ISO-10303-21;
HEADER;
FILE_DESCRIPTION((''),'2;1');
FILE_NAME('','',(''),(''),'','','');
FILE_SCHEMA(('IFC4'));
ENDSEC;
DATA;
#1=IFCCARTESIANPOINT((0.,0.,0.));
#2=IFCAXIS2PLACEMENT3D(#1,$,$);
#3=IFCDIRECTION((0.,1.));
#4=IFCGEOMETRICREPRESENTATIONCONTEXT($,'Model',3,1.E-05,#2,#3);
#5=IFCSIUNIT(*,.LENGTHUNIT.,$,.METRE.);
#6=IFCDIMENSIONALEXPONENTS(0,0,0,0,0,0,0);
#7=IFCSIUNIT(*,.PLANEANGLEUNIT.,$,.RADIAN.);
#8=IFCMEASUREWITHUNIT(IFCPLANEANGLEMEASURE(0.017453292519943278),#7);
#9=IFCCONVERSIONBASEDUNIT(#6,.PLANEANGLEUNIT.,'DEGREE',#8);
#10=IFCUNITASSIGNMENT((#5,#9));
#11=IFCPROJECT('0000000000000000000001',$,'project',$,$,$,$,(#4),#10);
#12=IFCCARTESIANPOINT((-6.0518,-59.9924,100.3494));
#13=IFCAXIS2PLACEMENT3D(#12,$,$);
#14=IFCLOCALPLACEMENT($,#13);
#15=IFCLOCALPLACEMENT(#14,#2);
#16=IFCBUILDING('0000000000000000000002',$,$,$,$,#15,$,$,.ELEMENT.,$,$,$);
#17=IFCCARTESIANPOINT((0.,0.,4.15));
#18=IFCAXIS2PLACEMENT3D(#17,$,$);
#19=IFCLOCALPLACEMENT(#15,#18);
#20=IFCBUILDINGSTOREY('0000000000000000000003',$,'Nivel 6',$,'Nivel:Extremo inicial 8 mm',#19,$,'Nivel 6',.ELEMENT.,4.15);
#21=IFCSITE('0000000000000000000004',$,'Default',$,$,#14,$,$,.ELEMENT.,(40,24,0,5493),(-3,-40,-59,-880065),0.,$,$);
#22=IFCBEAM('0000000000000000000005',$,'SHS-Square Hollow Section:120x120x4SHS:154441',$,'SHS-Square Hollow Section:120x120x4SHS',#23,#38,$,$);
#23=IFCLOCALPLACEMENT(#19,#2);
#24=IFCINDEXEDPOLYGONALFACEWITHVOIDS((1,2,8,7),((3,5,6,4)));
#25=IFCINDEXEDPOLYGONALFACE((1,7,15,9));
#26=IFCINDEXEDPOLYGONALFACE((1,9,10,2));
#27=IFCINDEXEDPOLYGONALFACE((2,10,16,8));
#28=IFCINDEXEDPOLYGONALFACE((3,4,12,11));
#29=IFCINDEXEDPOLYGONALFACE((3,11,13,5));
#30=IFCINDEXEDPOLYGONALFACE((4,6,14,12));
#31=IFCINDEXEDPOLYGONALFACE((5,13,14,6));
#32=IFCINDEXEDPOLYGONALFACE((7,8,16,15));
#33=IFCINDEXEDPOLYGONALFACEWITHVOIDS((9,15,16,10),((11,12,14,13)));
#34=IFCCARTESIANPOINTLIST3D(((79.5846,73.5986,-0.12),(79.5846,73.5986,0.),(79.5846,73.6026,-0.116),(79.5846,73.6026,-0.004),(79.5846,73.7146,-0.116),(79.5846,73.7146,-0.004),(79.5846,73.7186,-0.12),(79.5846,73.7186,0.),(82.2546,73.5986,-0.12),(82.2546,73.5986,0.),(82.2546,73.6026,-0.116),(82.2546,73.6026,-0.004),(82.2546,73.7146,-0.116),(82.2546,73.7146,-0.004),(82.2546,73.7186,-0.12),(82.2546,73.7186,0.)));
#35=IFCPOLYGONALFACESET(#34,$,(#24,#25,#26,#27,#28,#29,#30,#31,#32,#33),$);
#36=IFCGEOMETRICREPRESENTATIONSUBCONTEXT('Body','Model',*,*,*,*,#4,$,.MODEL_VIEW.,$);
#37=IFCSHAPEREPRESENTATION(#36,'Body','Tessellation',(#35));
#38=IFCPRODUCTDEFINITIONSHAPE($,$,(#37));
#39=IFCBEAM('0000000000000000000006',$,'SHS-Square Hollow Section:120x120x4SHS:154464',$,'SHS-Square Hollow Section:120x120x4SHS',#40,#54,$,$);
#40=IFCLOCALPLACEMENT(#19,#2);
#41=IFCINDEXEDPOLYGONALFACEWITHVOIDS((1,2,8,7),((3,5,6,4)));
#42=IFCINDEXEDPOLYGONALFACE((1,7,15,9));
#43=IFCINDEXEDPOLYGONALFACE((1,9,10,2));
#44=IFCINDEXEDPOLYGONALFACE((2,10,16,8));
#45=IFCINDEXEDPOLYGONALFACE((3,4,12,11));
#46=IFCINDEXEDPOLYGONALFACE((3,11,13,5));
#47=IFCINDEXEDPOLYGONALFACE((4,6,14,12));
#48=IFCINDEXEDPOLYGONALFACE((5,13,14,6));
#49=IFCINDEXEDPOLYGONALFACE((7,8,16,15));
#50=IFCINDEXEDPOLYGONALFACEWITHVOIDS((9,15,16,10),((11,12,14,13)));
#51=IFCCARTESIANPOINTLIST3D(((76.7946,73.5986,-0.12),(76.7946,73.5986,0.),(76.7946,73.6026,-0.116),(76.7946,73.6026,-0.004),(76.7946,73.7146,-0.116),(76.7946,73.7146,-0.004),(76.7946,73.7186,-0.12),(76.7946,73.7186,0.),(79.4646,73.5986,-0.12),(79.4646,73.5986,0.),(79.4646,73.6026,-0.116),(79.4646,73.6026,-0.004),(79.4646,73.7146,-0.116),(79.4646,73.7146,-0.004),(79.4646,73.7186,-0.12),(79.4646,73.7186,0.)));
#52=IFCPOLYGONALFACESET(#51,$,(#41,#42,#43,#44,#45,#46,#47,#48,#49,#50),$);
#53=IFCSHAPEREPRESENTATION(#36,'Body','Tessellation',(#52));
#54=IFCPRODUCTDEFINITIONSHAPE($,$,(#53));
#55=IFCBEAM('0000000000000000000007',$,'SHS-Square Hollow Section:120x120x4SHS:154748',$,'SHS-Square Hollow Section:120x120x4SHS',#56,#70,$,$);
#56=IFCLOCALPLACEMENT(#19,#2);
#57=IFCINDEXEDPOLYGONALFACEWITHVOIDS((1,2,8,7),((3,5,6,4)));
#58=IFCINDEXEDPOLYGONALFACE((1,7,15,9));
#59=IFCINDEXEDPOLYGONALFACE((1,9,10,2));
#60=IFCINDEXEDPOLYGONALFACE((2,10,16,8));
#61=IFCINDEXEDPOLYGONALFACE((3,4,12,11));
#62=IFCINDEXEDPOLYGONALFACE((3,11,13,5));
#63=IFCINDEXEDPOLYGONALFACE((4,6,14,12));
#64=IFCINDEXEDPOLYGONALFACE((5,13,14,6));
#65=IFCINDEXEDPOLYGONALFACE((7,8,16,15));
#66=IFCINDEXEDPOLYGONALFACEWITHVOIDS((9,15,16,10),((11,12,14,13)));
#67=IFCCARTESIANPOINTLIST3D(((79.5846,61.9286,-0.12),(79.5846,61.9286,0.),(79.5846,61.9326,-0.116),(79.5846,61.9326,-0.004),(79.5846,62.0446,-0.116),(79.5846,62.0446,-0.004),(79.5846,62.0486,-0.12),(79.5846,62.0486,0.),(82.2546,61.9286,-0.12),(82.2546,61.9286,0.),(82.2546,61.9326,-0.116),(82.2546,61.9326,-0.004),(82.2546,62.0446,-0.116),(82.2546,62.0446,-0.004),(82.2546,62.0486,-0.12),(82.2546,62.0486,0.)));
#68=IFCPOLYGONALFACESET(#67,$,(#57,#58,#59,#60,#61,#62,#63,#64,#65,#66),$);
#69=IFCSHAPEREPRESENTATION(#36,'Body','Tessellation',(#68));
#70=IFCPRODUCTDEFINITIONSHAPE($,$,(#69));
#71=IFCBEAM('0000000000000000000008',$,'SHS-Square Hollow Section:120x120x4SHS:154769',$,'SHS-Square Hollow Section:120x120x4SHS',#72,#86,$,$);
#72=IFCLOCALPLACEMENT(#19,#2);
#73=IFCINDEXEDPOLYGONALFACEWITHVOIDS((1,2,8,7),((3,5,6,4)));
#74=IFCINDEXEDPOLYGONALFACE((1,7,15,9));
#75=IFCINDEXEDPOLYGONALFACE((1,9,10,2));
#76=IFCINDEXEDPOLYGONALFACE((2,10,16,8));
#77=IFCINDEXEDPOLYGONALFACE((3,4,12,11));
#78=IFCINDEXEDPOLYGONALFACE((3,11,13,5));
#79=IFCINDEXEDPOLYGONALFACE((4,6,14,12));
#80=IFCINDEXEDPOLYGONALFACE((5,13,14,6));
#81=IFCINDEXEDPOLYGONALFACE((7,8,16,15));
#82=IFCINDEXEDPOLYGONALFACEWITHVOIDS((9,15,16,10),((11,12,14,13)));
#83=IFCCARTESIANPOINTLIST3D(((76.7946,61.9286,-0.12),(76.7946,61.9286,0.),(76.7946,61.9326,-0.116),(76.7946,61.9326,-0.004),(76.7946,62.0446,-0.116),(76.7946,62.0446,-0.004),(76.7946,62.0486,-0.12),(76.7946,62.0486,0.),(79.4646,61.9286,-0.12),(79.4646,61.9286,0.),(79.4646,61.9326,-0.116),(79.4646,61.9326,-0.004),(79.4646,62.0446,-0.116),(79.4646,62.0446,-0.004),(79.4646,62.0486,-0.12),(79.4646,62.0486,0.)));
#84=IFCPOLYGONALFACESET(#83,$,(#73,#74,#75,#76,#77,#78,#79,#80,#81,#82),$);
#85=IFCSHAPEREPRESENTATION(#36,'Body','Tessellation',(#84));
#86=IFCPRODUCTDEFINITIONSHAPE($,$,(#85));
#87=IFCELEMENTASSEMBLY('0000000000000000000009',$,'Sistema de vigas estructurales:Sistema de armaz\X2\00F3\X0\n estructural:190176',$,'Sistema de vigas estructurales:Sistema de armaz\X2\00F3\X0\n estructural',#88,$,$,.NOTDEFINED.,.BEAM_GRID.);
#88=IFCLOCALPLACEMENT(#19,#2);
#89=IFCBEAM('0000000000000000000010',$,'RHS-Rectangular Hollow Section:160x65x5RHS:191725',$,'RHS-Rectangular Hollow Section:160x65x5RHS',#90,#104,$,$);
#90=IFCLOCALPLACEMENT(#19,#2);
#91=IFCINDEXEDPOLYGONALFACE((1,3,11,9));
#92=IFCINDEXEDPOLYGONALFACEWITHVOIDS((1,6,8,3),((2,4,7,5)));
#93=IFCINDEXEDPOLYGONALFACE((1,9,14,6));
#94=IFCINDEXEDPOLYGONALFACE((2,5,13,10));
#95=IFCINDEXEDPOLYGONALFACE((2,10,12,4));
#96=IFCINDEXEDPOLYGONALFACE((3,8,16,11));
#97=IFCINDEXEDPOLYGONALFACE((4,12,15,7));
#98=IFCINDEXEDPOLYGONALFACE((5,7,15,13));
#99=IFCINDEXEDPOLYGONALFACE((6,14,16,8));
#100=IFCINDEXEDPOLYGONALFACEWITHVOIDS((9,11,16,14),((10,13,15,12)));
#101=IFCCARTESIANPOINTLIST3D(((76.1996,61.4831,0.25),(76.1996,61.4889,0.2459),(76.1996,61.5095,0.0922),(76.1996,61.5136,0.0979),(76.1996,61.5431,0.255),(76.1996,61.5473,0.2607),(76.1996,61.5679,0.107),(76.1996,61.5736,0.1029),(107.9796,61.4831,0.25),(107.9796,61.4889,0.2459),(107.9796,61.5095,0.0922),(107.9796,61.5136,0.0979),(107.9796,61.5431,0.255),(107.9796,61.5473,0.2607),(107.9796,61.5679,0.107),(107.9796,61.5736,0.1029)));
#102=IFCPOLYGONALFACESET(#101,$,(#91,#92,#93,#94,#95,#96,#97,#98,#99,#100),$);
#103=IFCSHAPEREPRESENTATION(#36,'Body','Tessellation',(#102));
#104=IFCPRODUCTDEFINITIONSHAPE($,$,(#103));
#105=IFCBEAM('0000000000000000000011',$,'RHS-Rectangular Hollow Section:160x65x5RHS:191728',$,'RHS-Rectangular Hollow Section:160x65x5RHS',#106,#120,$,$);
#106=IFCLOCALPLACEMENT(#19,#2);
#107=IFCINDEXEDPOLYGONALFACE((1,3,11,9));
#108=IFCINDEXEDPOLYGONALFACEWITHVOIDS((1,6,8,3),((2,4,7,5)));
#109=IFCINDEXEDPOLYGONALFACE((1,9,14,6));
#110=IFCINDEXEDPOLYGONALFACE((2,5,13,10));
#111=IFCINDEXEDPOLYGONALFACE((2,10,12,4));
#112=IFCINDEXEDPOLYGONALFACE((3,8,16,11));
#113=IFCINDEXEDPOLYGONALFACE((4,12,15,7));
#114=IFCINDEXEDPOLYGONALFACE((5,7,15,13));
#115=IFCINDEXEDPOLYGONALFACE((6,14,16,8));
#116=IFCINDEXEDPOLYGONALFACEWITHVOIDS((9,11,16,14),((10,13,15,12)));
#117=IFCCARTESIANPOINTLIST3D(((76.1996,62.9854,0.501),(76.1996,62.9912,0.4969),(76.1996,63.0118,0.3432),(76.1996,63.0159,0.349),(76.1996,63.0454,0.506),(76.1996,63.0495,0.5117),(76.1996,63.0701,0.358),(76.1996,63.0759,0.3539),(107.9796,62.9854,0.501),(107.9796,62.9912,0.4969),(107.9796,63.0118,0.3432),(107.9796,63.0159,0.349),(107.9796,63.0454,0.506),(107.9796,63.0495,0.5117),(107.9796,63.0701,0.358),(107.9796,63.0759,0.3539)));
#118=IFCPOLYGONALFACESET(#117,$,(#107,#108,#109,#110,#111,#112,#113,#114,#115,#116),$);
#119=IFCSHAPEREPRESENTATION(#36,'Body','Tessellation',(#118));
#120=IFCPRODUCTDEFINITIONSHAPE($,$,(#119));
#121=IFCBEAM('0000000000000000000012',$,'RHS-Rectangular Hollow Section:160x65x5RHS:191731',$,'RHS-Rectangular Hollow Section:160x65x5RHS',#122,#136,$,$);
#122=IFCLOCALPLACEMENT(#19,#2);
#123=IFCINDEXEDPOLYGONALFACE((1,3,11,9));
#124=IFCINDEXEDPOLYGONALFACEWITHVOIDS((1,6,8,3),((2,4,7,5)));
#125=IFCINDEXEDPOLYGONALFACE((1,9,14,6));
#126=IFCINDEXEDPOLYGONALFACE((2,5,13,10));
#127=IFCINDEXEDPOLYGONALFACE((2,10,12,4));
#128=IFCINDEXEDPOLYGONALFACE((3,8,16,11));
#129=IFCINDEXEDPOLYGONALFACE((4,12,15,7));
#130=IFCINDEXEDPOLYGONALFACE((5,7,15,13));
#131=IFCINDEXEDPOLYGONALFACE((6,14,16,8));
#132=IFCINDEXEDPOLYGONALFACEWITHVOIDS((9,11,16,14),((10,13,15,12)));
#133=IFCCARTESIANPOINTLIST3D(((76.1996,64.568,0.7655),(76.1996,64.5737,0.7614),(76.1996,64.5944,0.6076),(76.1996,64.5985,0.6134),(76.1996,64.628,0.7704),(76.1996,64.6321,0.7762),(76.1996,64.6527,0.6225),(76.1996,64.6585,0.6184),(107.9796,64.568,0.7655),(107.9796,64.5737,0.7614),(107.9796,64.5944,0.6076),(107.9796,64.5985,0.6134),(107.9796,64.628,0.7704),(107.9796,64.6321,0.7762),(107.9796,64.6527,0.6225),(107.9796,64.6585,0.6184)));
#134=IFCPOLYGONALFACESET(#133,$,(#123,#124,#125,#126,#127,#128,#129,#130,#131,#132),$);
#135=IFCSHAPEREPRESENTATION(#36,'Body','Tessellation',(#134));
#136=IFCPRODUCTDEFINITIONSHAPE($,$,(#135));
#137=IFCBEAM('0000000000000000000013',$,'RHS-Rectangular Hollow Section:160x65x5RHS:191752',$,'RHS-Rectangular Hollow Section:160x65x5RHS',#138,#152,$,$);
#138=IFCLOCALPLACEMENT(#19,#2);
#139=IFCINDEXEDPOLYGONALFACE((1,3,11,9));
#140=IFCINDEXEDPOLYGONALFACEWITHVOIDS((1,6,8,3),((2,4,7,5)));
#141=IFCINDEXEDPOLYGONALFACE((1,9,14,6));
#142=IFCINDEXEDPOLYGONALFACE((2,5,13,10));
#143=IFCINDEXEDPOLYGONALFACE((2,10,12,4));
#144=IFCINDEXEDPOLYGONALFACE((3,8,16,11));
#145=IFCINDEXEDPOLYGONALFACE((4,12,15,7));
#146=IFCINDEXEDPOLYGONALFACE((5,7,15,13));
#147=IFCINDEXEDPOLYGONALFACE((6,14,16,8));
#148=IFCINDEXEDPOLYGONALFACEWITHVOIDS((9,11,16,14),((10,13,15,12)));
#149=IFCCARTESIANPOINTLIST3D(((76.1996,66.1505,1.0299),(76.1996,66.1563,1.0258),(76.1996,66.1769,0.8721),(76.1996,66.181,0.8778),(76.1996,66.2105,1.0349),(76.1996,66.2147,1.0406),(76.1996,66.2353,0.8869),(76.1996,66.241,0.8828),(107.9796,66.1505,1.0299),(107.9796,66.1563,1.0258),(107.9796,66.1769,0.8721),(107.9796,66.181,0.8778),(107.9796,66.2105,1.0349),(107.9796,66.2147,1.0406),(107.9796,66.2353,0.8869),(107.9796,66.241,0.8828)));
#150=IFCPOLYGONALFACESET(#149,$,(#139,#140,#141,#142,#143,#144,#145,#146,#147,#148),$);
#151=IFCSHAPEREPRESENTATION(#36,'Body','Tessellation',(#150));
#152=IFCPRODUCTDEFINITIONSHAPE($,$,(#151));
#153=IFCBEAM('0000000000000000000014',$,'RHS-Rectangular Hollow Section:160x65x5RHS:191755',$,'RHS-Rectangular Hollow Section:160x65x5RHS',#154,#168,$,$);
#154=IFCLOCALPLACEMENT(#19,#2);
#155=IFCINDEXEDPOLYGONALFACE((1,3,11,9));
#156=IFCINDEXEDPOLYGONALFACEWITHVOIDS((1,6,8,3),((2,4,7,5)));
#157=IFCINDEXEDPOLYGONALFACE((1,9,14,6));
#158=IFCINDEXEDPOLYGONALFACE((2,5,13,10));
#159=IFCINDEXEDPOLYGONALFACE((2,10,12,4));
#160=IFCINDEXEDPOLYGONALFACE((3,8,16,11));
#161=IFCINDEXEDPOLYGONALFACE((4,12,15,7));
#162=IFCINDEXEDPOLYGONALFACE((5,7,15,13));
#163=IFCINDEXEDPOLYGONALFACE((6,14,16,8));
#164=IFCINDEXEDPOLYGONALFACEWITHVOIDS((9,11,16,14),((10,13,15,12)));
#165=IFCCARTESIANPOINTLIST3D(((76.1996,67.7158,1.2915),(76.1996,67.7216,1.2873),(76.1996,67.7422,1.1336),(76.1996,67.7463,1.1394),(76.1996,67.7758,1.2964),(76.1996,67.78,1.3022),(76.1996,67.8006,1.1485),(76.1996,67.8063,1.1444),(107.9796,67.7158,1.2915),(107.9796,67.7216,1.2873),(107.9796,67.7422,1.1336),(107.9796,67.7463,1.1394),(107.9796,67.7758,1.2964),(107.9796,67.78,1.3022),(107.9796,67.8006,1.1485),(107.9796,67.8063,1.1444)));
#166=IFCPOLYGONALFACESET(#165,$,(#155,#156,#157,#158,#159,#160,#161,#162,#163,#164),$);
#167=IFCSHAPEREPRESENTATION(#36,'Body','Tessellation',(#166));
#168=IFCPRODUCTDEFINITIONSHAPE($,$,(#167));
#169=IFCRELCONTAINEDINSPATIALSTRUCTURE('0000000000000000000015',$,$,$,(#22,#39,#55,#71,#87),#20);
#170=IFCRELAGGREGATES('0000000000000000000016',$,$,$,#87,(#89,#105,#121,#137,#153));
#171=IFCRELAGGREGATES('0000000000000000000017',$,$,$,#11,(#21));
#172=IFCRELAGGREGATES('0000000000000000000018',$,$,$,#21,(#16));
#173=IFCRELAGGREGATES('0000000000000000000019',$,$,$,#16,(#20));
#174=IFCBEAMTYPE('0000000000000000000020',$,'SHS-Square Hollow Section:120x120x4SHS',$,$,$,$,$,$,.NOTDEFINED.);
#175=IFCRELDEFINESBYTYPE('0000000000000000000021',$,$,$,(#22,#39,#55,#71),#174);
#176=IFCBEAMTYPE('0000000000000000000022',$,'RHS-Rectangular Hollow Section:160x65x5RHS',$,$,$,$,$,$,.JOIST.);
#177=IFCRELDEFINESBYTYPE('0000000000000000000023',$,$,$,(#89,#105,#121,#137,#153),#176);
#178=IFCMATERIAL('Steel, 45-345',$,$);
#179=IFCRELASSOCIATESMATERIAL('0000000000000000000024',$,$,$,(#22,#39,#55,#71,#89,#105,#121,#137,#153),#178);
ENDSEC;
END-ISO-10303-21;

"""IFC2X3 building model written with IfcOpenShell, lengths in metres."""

from ifc_helpers import new_model, entity, si_unit, converted_unit, direction, frame, frame_2d, origin, place, context, subcontext, project, spatial, rectangle, extrude, boolean, material, type_object, element, aggregate, save


model = new_model("IFC2X3")

# Units and contexts
model_context = context("Model", 3, precision=1e-05, world=origin(), true_north=direction((0.0, 1.0)))
body_context = subcontext(model_context, "Body", "Model", "MODEL_VIEW")
ifc_project = project(units=[si_unit("LENGTHUNIT", "METRE"), converted_unit("PLANEANGLEUNIT", "DEGREE", entity("IfcPlaneAngleMeasure", 0.017453292519943278), si_unit("PLANEANGLEUNIT", "RADIAN"), dimensions=[0, 0, 0, 0, 0, 0, 0])], contexts=[model_context])

# Site, building, storey
site_placement = place(None, frame((-6.0518, -59.9924, 100.3494)))
site = spatial("IfcSite", under=ifc_project, at=site_placement, Name="Default", CompositionType="ELEMENT", RefLatitude=(40, 24, 0, 5493), RefLongitude=(-3, -40, -59, -880065), RefElevation=0.0)
building_placement = place(site_placement, origin())
building = spatial("IfcBuilding", under=site, at=building_placement, CompositionType="ELEMENT")
storey_placement = place(building_placement, frame((0.0, 0.0, 4.15)))
storey = spatial("IfcBuildingStorey", under=building, at=storey_placement, Name="Nivel 6", ObjectType="Nivel:Extremo inicial 8 mm", LongName="Nivel 6", CompositionType="ELEMENT", Elevation=4.15)

# Beams
ifc_material_1 = material(Name="Steel, 45-345")
beam_type_1 = type_object("IfcBeamType", Name="SHS-Square Hollow Section:120x120x4SHS", PredefinedType="NOTDEFINED")
beam_1_placement = place(storey_placement, frame((82.3146, 73.6586, 0.0), z_axis=(0.0, 0.0, 1.0), x_axis=(-1.0, 0.0, 0.0)))
element("IfcBeam", 1, at=beam_1_placement, inside=storey, type_object=beam_type_1, material=ifc_material_1, Name="SHS-Square Hollow Section:120x120x4SHS:154441", ObjectType="SHS-Square Hollow Section:120x120x4SHS", context=body_context, shape_type="SweptSolid", body=[
    boolean("DIFFERENCE", extrude(rectangle(XDim=0.12, YDim=0.12, at=frame_2d((0.0, 0.0), x_axis=(1.0, 0.0))), frame((0.06, 0.0, -0.06), z_axis=(1.0, 0.0, 0.0), x_axis=(0.0, 0.0, -1.0)), (0.0, 0.0, 1.0), 2.67), extrude(rectangle(XDim=0.112, YDim=0.112, at=frame_2d((0.0, 0.0), x_axis=(0.0, 1.0))), frame((2.73, 0.0, -0.06), z_axis=(-1.0, 0.0, 0.0), x_axis=(0.0, 1.0, 0.0)), (0.0, 0.0, 1.0), 2.67)),
])
beam_2_placement = place(storey_placement, frame((79.5246, 73.6586, 0.0), z_axis=(0.0, 0.0, 1.0), x_axis=(-1.0, 0.0, 0.0)))
element("IfcBeam", 2, at=beam_2_placement, inside=storey, type_object=beam_type_1, material=ifc_material_1, Name="SHS-Square Hollow Section:120x120x4SHS:154464", ObjectType="SHS-Square Hollow Section:120x120x4SHS", context=body_context, shape_type="SweptSolid", body=[
    boolean("DIFFERENCE", extrude(rectangle(XDim=0.12, YDim=0.12, at=frame_2d((0.0, 0.0), x_axis=(1.0, 0.0))), frame((0.06, 0.0, -0.06), z_axis=(1.0, 0.0, 0.0), x_axis=(0.0, 0.0, -1.0)), (0.0, 0.0, 1.0), 2.67), extrude(rectangle(XDim=0.112, YDim=0.112, at=frame_2d((0.0, 0.0), x_axis=(0.0, 1.0))), frame((2.73, 0.0, -0.06), z_axis=(-1.0, 0.0, 0.0), x_axis=(0.0, 1.0, 0.0)), (0.0, 0.0, 1.0), 2.67)),
])
beam_3_placement = place(storey_placement, frame((82.3146, 61.9886, 0.0), z_axis=(0.0, 0.0, 1.0), x_axis=(-1.0, 0.0, 0.0)))
element("IfcBeam", 3, at=beam_3_placement, inside=storey, type_object=beam_type_1, material=ifc_material_1, Name="SHS-Square Hollow Section:120x120x4SHS:154748", ObjectType="SHS-Square Hollow Section:120x120x4SHS", context=body_context, shape_type="SweptSolid", body=[
    boolean("DIFFERENCE", extrude(rectangle(XDim=0.12, YDim=0.12, at=frame_2d((0.0, 0.0), x_axis=(1.0, 0.0))), frame((0.06, 0.0, -0.06), z_axis=(1.0, 0.0, 0.0), x_axis=(0.0, 0.0, -1.0)), (0.0, 0.0, 1.0), 2.67), extrude(rectangle(XDim=0.112, YDim=0.112, at=frame_2d((0.0, 0.0), x_axis=(0.0, 1.0))), frame((2.73, 0.0, -0.06), z_axis=(-1.0, 0.0, 0.0), x_axis=(0.0, 1.0, 0.0)), (0.0, 0.0, 1.0), 2.67)),
])
beam_4_placement = place(storey_placement, frame((79.5246, 61.9886, 0.0), z_axis=(0.0, 0.0, 1.0), x_axis=(-1.0, 0.0, 0.0)))
element("IfcBeam", 4, at=beam_4_placement, inside=storey, type_object=beam_type_1, material=ifc_material_1, Name="SHS-Square Hollow Section:120x120x4SHS:154769", ObjectType="SHS-Square Hollow Section:120x120x4SHS", context=body_context, shape_type="SweptSolid", body=[
    boolean("DIFFERENCE", extrude(rectangle(XDim=0.12, YDim=0.12, at=frame_2d((0.0, 0.0), x_axis=(1.0, 0.0))), frame((0.06, 0.0, -0.06), z_axis=(1.0, 0.0, 0.0), x_axis=(0.0, 0.0, -1.0)), (0.0, 0.0, 1.0), 2.67), extrude(rectangle(XDim=0.112, YDim=0.112, at=frame_2d((0.0, 0.0), x_axis=(0.0, 1.0))), frame((2.73, 0.0, -0.06), z_axis=(-1.0, 0.0, 0.0), x_axis=(0.0, 1.0, 0.0)), (0.0, 0.0, 1.0), 2.67)),
])

# Element assembly, beams
assembly_placement = place(storey_placement, origin())
assembly = element("IfcElementAssembly", 5, at=assembly_placement, inside=storey, Name="Sistema de vigas estructurales:Sistema de armazón estructural:190176", ObjectType="Sistema de vigas estructurales:Sistema de armazón estructural", AssemblyPlace="NOTDEFINED", PredefinedType="BEAM_GRID")
beam_type_2 = type_object("IfcBeamType", Name="RHS-Rectangular Hollow Section:160x65x5RHS", PredefinedType="JOIST")
beam_5_placement = place(assembly_placement, frame((76.1996, 61.5679, -0.0603)))
beam_5 = element("IfcBeam", 6, at=beam_5_placement, type_object=beam_type_2, material=ifc_material_1, Name="RHS-Rectangular Hollow Section:160x65x5RHS:191725", ObjectType="RHS-Rectangular Hollow Section:160x65x5RHS", context=body_context, shape_type="SweptSolid", body=[
    boolean("DIFFERENCE", extrude(rectangle(XDim=0.16, YDim=0.065, at=frame_2d((0.0, 0.0), x_axis=(0.0, 1.0))), frame((0.0, -0.0396, 0.2367), z_axis=(1.0, 0.0, 0.0), x_axis=(0.0, -0.986325, -0.16481)), (0.0, 0.0, 1.0), 31.78), extrude(rectangle(XDim=0.15, YDim=0.055, at=frame_2d((0.0, 0.0), x_axis=(0.0, 1.0))), frame((31.78, -0.0396, 0.2367), z_axis=(-1.0, 0.0, 0.0), x_axis=(0.0, 0.986325, 0.16481)), (0.0, 0.0, 1.0), 31.78)),
])
beam_6_placement = place(assembly_placement, frame((76.1996, 63.0702, 0.1908)))
beam_6 = element("IfcBeam", 7, at=beam_6_placement, type_object=beam_type_2, material=ifc_material_1, Name="RHS-Rectangular Hollow Section:160x65x5RHS:191728", ObjectType="RHS-Rectangular Hollow Section:160x65x5RHS", context=body_context, shape_type="SweptSolid", body=[
    boolean("DIFFERENCE", extrude(rectangle(XDim=0.16, YDim=0.065, at=frame_2d((0.0, 0.0), x_axis=(0.0, 1.0))), frame((0.0, -0.0396, 0.2367), z_axis=(1.0, 0.0, 0.0), x_axis=(0.0, -0.986325, -0.16481)), (0.0, 0.0, 1.0), 31.78), extrude(rectangle(XDim=0.15, YDim=0.055, at=frame_2d((0.0, 0.0), x_axis=(0.0, 1.0))), frame((31.78, -0.0396, 0.2367), z_axis=(-1.0, 0.0, 0.0), x_axis=(0.0, 0.986325, 0.16481)), (0.0, 0.0, 1.0), 31.78)),
])
beam_7_placement = place(assembly_placement, frame((76.1996, 64.6528, 0.4552)))
beam_7 = element("IfcBeam", 8, at=beam_7_placement, type_object=beam_type_2, material=ifc_material_1, Name="RHS-Rectangular Hollow Section:160x65x5RHS:191731", ObjectType="RHS-Rectangular Hollow Section:160x65x5RHS", context=body_context, shape_type="SweptSolid", body=[
    boolean("DIFFERENCE", extrude(rectangle(XDim=0.16, YDim=0.065, at=frame_2d((0.0, 0.0), x_axis=(0.0, 1.0))), frame((0.0, -0.0396, 0.2367), z_axis=(1.0, 0.0, 0.0), x_axis=(0.0, -0.986325, -0.16481)), (0.0, 0.0, 1.0), 31.78), extrude(rectangle(XDim=0.15, YDim=0.055, at=frame_2d((0.0, 0.0), x_axis=(0.0, 1.0))), frame((31.78, -0.0396, 0.2367), z_axis=(-1.0, 0.0, 0.0), x_axis=(0.0, 0.986325, 0.16481)), (0.0, 0.0, 1.0), 31.78)),
])
beam_8_placement = place(assembly_placement, frame((76.1996, 66.2353, 0.7196)))
beam_8 = element("IfcBeam", 9, at=beam_8_placement, type_object=beam_type_2, material=ifc_material_1, Name="RHS-Rectangular Hollow Section:160x65x5RHS:191752", ObjectType="RHS-Rectangular Hollow Section:160x65x5RHS", context=body_context, shape_type="SweptSolid", body=[
    boolean("DIFFERENCE", extrude(rectangle(XDim=0.16, YDim=0.065, at=frame_2d((0.0, 0.0), x_axis=(0.0, 1.0))), frame((0.0, -0.0396, 0.2367), z_axis=(1.0, 0.0, 0.0), x_axis=(0.0, -0.986325, -0.16481)), (0.0, 0.0, 1.0), 31.78), extrude(rectangle(XDim=0.15, YDim=0.055, at=frame_2d((0.0, 0.0), x_axis=(0.0, 1.0))), frame((31.78, -0.0396, 0.2367), z_axis=(-1.0, 0.0, 0.0), x_axis=(0.0, 0.986325, 0.16481)), (0.0, 0.0, 1.0), 31.78)),
])
beam_9_placement = place(assembly_placement, frame((76.1996, 67.8006, 0.9812)))
beam_9 = element("IfcBeam", 10, at=beam_9_placement, type_object=beam_type_2, material=ifc_material_1, Name="RHS-Rectangular Hollow Section:160x65x5RHS:191755", ObjectType="RHS-Rectangular Hollow Section:160x65x5RHS", context=body_context, shape_type="SweptSolid", body=[
    boolean("DIFFERENCE", extrude(rectangle(XDim=0.16, YDim=0.065, at=frame_2d((0.0, 0.0), x_axis=(0.0, 1.0))), frame((0.0, -0.0396, 0.2367), z_axis=(1.0, 0.0, 0.0), x_axis=(0.0, -0.986325, -0.16481)), (0.0, 0.0, 1.0), 31.78), extrude(rectangle(XDim=0.15, YDim=0.055, at=frame_2d((0.0, 0.0), x_axis=(0.0, 1.0))), frame((31.78, -0.0396, 0.2367), z_axis=(-1.0, 0.0, 0.0), x_axis=(0.0, 0.986325, 0.16481)), (0.0, 0.0, 1.0), 31.78)),
])
aggregate(assembly, [beam_5, beam_6, beam_7, beam_8, beam_9])

save(model, "model.ifc")
